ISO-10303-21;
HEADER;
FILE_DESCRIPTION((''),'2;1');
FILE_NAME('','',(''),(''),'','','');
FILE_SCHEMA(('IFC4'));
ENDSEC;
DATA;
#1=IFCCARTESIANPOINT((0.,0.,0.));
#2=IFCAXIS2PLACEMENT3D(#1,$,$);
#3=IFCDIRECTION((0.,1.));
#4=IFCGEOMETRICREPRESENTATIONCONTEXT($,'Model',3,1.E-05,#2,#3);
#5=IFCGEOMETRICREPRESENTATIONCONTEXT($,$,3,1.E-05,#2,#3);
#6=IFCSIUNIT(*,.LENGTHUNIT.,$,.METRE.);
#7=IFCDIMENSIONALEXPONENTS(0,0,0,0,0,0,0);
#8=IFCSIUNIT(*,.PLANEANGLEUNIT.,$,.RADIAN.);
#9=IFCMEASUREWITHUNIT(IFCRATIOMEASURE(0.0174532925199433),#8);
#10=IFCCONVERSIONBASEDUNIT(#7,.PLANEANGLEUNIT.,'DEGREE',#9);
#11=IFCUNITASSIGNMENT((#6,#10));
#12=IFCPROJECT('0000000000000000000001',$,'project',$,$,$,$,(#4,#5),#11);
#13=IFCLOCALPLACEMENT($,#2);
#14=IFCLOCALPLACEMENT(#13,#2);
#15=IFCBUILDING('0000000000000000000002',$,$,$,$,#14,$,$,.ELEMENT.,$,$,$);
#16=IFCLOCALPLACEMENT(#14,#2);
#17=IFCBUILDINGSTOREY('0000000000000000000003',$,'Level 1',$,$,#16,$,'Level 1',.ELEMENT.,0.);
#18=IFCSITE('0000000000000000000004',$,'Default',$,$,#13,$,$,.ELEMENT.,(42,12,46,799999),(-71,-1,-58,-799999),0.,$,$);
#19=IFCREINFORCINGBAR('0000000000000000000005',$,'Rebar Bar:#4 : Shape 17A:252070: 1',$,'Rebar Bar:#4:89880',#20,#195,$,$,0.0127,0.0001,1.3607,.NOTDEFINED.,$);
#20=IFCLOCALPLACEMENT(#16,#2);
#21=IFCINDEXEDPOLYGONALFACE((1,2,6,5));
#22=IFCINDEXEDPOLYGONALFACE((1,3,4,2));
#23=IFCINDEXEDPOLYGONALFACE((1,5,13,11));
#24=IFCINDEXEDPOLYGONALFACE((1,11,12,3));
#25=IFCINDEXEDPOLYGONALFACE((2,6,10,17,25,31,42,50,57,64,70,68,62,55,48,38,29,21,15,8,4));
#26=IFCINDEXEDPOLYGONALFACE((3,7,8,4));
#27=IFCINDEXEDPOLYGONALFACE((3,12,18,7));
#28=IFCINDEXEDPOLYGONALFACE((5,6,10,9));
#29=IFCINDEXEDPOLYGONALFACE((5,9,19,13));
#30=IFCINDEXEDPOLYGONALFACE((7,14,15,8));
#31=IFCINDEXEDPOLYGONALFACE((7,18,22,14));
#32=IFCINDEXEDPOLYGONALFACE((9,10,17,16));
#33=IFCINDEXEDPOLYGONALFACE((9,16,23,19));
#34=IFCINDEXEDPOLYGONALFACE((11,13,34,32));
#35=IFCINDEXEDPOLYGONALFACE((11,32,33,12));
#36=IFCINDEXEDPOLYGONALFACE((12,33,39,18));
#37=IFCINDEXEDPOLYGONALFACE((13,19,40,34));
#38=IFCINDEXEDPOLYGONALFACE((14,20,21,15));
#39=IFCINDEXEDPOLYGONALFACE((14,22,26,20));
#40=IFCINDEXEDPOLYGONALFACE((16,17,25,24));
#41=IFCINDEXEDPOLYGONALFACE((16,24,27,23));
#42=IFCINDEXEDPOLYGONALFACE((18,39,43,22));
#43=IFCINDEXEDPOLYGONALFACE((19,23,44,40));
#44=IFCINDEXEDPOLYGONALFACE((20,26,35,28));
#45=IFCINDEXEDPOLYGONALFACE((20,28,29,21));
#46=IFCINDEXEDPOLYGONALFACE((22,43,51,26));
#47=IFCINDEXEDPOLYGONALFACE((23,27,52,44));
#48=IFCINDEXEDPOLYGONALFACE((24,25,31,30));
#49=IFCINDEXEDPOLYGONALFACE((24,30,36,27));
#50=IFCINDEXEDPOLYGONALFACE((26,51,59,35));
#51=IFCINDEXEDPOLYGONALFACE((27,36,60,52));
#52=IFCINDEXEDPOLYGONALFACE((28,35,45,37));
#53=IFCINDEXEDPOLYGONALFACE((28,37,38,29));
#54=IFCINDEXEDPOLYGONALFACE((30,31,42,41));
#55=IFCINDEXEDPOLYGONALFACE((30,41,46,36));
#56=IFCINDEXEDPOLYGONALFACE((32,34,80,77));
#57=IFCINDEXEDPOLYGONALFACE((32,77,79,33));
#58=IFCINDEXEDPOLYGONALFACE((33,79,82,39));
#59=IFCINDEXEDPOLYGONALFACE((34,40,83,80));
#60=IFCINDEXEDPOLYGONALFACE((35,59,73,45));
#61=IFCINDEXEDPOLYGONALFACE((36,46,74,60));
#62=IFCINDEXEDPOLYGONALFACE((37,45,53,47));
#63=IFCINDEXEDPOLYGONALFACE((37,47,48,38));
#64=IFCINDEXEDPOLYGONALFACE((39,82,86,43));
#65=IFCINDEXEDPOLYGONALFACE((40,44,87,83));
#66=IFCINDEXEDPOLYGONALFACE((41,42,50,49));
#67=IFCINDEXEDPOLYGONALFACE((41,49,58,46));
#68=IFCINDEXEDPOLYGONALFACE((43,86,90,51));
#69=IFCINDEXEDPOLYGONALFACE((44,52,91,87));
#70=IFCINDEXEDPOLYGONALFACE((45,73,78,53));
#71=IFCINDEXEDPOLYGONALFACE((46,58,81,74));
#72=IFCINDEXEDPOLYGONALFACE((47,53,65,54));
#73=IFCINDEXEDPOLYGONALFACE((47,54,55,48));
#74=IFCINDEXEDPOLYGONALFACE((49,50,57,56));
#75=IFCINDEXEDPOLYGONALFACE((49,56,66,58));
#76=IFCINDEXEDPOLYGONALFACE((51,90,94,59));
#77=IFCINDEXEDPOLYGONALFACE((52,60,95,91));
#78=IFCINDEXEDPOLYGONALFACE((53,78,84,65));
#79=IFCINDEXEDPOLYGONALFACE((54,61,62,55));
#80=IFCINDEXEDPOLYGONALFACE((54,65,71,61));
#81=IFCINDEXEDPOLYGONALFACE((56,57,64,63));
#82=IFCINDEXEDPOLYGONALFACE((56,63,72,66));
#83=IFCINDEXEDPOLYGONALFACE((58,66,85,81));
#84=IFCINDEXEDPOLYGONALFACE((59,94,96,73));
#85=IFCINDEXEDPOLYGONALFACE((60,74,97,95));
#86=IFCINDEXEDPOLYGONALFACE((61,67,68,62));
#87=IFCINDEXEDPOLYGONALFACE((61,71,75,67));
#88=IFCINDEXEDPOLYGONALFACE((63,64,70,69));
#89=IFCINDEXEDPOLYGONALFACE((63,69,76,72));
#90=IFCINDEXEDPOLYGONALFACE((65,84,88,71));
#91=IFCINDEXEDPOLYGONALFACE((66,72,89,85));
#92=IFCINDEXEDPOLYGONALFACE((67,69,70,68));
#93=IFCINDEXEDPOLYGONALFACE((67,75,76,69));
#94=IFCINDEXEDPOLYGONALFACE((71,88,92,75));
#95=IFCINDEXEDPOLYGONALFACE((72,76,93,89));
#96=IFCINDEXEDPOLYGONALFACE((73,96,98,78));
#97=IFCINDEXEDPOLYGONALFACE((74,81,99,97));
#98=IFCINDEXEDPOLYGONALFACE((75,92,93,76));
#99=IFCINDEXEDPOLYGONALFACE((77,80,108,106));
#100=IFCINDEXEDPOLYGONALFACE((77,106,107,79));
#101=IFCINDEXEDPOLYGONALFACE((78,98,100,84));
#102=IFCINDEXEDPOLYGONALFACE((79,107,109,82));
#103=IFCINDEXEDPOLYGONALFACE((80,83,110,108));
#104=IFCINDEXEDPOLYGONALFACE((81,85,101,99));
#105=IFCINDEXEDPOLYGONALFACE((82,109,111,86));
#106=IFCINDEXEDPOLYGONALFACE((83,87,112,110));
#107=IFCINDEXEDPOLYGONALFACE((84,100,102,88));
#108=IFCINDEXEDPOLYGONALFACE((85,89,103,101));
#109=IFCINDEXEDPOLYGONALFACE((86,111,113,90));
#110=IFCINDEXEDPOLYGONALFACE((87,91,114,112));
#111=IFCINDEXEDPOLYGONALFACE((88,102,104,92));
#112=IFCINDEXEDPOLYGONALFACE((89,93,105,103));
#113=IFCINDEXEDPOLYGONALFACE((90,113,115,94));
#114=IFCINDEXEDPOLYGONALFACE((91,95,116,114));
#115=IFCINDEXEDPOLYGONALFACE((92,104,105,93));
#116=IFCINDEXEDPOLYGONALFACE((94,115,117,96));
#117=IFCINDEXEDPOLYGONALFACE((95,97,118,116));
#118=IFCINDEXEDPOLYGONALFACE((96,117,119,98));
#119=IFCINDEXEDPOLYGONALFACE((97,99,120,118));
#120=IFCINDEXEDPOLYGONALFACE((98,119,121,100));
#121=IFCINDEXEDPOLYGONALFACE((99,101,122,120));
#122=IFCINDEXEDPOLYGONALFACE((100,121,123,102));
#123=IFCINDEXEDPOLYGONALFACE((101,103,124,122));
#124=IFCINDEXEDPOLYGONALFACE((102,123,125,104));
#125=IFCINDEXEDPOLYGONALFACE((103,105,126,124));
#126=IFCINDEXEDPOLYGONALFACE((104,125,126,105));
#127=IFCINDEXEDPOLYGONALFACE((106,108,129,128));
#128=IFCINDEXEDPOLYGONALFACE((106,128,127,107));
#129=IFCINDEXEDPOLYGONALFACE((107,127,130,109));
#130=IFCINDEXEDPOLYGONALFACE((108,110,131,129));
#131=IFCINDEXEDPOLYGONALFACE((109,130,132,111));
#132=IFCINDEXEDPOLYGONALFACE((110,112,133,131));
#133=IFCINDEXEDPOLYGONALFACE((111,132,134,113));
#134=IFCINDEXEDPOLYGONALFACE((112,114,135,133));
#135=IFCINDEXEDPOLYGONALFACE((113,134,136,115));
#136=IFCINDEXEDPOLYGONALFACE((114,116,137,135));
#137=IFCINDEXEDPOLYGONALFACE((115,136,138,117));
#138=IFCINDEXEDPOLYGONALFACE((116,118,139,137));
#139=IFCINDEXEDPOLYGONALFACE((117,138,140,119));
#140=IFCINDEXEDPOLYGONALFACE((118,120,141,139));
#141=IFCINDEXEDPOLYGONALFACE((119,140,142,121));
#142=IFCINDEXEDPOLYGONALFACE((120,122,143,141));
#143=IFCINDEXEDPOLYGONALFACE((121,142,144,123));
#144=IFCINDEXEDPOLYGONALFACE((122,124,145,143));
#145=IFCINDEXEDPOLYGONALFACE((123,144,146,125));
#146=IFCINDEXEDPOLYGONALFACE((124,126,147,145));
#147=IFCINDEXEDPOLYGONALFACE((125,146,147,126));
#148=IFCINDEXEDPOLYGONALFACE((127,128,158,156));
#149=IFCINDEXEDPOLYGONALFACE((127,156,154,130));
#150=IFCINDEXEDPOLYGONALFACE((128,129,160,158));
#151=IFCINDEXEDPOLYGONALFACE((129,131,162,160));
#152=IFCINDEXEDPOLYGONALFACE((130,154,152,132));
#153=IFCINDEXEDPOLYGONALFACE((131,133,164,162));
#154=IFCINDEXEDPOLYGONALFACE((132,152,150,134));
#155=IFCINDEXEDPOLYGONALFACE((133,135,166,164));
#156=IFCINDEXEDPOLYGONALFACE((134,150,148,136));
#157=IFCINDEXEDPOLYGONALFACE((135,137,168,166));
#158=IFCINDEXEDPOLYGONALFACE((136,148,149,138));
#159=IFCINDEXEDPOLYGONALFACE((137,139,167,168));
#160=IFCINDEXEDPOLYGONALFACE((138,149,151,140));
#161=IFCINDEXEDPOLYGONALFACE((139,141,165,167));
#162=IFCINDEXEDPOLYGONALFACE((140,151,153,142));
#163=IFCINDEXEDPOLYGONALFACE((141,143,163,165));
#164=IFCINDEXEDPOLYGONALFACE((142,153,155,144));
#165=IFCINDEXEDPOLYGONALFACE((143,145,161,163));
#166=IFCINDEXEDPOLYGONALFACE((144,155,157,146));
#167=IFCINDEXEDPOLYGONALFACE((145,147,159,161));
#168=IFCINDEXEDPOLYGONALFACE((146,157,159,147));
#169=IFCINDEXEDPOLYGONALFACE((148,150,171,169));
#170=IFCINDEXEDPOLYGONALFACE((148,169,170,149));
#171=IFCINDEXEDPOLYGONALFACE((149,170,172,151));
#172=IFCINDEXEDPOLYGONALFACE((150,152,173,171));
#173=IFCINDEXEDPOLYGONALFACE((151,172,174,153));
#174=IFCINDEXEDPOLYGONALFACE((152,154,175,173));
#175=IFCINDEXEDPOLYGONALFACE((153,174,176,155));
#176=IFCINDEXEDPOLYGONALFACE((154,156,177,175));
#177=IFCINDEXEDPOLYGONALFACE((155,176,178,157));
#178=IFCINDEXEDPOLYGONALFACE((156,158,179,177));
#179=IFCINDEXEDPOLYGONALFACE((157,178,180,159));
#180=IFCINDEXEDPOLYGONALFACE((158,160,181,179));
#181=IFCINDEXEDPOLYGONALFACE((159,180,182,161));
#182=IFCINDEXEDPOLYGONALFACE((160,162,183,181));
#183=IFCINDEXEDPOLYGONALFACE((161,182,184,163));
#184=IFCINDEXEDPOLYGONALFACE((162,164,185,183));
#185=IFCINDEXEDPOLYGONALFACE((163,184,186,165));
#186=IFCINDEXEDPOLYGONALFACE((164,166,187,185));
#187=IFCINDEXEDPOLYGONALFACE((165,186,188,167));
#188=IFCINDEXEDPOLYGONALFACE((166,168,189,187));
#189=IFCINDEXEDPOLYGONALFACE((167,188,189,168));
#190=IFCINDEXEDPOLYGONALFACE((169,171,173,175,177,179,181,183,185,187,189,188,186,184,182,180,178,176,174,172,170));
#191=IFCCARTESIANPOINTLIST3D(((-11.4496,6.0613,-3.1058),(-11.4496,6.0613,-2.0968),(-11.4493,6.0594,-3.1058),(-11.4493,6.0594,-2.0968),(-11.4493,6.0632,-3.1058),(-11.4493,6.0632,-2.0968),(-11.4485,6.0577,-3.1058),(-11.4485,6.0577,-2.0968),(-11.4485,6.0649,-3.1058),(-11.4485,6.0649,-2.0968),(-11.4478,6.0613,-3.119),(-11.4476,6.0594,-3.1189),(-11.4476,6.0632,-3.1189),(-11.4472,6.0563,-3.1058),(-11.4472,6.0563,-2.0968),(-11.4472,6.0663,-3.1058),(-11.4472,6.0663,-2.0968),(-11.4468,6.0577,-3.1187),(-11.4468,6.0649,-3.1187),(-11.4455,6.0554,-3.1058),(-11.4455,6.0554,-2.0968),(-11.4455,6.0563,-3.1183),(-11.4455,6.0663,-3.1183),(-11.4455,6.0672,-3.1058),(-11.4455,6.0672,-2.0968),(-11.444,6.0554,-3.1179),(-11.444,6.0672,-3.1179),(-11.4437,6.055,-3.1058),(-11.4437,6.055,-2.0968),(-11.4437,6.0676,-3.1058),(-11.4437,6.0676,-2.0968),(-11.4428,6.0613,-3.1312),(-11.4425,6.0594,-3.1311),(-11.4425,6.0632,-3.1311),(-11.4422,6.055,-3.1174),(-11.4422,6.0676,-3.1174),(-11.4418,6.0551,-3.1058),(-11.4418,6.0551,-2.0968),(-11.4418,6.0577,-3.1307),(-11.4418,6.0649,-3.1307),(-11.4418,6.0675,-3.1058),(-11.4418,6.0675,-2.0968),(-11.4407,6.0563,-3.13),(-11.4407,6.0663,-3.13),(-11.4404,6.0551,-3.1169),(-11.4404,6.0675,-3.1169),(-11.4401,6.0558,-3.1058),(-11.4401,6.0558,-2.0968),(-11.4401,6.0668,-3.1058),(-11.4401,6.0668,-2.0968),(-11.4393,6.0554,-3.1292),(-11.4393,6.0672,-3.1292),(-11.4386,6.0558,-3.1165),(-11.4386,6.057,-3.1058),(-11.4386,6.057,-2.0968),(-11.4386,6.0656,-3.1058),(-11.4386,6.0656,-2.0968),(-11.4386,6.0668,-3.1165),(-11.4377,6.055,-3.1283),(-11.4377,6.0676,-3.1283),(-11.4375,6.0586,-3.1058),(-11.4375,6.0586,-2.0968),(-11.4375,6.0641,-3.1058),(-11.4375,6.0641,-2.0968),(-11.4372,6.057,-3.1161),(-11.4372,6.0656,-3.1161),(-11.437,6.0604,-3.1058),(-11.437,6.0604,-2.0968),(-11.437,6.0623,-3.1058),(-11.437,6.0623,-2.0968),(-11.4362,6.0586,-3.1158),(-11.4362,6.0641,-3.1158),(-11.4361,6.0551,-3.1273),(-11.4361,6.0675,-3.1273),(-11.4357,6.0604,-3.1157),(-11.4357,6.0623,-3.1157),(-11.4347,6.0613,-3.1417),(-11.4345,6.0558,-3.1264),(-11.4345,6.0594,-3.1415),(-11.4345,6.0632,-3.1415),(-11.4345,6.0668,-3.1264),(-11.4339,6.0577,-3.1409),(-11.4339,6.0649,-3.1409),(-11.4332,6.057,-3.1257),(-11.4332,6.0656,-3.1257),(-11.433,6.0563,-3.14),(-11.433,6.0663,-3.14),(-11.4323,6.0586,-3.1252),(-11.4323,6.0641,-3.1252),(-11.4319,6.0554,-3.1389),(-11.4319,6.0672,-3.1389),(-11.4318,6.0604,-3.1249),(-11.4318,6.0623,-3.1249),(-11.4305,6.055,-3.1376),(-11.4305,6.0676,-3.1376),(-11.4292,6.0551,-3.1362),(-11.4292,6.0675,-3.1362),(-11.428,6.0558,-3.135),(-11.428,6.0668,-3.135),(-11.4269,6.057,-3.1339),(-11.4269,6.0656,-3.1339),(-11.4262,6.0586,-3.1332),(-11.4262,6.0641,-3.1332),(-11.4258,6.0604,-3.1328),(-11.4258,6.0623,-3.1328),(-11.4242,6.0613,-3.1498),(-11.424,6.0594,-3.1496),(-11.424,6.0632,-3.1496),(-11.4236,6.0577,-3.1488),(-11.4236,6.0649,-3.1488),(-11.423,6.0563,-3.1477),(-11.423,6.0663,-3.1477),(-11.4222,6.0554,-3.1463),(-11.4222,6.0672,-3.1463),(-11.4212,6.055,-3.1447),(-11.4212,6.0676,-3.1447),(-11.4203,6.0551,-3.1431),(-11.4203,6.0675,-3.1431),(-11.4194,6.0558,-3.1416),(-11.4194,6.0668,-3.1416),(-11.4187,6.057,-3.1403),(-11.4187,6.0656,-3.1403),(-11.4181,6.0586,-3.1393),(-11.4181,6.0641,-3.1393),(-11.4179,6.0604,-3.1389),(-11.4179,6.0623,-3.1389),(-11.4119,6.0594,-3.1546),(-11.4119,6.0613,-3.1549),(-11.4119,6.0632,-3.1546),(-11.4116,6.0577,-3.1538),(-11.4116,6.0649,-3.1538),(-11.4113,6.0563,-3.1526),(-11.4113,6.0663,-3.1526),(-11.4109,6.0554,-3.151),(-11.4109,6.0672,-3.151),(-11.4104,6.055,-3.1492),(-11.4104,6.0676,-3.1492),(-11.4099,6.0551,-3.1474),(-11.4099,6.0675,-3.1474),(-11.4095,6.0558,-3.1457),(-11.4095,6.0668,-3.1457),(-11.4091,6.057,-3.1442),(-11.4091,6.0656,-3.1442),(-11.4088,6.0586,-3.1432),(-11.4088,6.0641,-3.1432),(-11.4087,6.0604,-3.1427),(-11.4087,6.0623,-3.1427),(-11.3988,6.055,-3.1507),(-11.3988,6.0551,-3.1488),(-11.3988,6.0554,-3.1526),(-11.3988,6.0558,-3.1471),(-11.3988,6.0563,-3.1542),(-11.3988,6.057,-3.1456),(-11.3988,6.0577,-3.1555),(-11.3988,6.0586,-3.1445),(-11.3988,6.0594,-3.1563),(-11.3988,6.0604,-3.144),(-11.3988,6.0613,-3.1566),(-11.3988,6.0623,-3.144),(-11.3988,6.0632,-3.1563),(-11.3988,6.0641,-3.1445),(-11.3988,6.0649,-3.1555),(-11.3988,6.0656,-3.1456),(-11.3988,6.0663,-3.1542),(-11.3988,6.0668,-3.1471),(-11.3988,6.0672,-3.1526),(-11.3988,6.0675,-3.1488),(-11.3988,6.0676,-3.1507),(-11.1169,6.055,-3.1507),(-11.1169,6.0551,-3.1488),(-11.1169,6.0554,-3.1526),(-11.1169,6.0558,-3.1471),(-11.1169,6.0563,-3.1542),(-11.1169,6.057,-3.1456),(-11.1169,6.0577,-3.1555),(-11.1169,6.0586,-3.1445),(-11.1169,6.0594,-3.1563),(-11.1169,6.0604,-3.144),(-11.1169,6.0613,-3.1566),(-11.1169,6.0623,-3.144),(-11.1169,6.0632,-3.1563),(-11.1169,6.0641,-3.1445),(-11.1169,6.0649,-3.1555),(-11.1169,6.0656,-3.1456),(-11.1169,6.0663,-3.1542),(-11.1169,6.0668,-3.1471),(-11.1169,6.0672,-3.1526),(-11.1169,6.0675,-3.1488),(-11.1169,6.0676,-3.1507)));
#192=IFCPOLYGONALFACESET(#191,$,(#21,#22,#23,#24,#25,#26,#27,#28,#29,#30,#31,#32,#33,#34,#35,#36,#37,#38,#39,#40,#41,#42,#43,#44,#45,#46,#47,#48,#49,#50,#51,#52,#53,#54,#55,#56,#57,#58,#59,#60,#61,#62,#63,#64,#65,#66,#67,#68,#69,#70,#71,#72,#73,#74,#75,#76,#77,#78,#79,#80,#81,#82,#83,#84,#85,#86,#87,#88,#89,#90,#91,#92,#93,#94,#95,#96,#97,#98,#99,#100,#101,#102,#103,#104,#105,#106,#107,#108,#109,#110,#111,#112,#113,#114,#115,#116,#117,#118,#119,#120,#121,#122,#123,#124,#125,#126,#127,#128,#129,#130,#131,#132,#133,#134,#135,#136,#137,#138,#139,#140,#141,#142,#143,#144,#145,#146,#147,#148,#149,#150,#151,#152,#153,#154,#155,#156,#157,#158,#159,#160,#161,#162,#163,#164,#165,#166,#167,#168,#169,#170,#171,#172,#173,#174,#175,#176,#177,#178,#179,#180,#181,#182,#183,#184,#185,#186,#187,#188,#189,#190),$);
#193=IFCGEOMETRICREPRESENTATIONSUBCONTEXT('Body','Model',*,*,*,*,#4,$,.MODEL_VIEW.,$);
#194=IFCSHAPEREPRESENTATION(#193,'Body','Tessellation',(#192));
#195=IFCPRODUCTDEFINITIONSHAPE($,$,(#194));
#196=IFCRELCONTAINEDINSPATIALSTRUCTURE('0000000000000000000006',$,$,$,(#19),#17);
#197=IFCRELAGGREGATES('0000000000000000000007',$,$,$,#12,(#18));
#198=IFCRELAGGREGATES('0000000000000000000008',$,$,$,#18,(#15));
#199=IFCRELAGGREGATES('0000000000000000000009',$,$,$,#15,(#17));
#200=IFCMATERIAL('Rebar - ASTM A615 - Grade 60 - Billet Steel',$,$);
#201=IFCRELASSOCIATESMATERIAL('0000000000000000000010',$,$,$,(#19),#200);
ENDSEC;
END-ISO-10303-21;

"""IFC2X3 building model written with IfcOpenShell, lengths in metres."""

from ifc_helpers import new_model, entity, si_unit, converted_unit, direction, origin, place, context, subcontext, project, spatial, material, element, save


model = new_model("IFC2X3")

# Units and contexts
model_context = context("Model", 3, precision=1e-05, world=origin(), true_north=direction((0.0, 1.0)))
context_of_model = context(None, 3, precision=1e-05, world=origin(), true_north=direction((0.0, 1.0)))
body_context = subcontext(model_context, "Body", "Model", "MODEL_VIEW")
ifc_project = project(units=[si_unit("LENGTHUNIT", "METRE"), converted_unit("PLANEANGLEUNIT", "DEGREE", entity("IfcRatioMeasure", 0.0174532925199433), si_unit("PLANEANGLEUNIT", "RADIAN"), dimensions=[0, 0, 0, 0, 0, 0, 0])], contexts=[model_context, context_of_model])

# Site, building, storey
site_placement = place(None, origin())
site = spatial("IfcSite", under=ifc_project, at=site_placement, Name="Default", CompositionType="ELEMENT", RefLatitude=(42, 12, 46, 799999), RefLongitude=(-71, -1, -58, -799999), RefElevation=0.0)
building_placement = place(site_placement, origin())
building = spatial("IfcBuilding", under=site, at=building_placement, CompositionType="ELEMENT")
storey_placement = place(building_placement, origin())
storey = spatial("IfcBuildingStorey", under=building, at=storey_placement, Name="Level 1", LongName="Level 1", CompositionType="ELEMENT", Elevation=0.0)

# Reinforcing bar
ifc_material_1 = material(Name="Rebar - ASTM A615 - Grade 60 - Billet Steel")
reinforcing_bar_1_placement = place(storey_placement, origin())
element("IfcReinforcingBar", 1, at=reinforcing_bar_1_placement, inside=storey, material=ifc_material_1, Name="Rebar Bar:#4 : Shape 17A:252070: 1", ObjectType="Rebar Bar:#4:89880", BarLength=1.3607, BarRole="NOTDEFINED", CrossSectionArea=0.0001, NominalDiameter=0.0127, context=body_context, shape_type="AdvancedSweptSolid", body=[
    entity("IfcSweptDiskSolid", entity("IfcCompositeCurve", [entity("IfcCompositeCurveSegment", "CONTINUOUS", True, entity("IfcPolyline", [entity("IfcCartesianPoint", [-11.4432, 6.0613, -2.0968]), entity("IfcCartesianPoint", [-11.4432, 6.0613, -3.1058])])), entity("IfcCompositeCurveSegment", "CONTINUOUS", True, entity("IfcTrimmedCurve", entity("IfcCircle", entity("IfcAxis2Placement3D", entity("IfcCartesianPoint", [-11.3988, 6.0613, -3.1058]), entity("IfcDirection", [0.0, -1.0, 0.0]), entity("IfcDirection", [0.0, 0.0, -1.0])), 0.0445), [entity("IfcParameterValue", 270.0)], [entity("IfcParameterValue", 360.0)], True, "PARAMETER")), entity("IfcCompositeCurveSegment", "CONTINUOUS", True, entity("IfcPolyline", [entity("IfcCartesianPoint", [-11.3988, 6.0613, -3.1503]), entity("IfcCartesianPoint", [-11.1169, 6.0613, -3.1503])]))], False), 0.0063, None, 0.0, 92.0),
])

save(model, "model.ifc")
